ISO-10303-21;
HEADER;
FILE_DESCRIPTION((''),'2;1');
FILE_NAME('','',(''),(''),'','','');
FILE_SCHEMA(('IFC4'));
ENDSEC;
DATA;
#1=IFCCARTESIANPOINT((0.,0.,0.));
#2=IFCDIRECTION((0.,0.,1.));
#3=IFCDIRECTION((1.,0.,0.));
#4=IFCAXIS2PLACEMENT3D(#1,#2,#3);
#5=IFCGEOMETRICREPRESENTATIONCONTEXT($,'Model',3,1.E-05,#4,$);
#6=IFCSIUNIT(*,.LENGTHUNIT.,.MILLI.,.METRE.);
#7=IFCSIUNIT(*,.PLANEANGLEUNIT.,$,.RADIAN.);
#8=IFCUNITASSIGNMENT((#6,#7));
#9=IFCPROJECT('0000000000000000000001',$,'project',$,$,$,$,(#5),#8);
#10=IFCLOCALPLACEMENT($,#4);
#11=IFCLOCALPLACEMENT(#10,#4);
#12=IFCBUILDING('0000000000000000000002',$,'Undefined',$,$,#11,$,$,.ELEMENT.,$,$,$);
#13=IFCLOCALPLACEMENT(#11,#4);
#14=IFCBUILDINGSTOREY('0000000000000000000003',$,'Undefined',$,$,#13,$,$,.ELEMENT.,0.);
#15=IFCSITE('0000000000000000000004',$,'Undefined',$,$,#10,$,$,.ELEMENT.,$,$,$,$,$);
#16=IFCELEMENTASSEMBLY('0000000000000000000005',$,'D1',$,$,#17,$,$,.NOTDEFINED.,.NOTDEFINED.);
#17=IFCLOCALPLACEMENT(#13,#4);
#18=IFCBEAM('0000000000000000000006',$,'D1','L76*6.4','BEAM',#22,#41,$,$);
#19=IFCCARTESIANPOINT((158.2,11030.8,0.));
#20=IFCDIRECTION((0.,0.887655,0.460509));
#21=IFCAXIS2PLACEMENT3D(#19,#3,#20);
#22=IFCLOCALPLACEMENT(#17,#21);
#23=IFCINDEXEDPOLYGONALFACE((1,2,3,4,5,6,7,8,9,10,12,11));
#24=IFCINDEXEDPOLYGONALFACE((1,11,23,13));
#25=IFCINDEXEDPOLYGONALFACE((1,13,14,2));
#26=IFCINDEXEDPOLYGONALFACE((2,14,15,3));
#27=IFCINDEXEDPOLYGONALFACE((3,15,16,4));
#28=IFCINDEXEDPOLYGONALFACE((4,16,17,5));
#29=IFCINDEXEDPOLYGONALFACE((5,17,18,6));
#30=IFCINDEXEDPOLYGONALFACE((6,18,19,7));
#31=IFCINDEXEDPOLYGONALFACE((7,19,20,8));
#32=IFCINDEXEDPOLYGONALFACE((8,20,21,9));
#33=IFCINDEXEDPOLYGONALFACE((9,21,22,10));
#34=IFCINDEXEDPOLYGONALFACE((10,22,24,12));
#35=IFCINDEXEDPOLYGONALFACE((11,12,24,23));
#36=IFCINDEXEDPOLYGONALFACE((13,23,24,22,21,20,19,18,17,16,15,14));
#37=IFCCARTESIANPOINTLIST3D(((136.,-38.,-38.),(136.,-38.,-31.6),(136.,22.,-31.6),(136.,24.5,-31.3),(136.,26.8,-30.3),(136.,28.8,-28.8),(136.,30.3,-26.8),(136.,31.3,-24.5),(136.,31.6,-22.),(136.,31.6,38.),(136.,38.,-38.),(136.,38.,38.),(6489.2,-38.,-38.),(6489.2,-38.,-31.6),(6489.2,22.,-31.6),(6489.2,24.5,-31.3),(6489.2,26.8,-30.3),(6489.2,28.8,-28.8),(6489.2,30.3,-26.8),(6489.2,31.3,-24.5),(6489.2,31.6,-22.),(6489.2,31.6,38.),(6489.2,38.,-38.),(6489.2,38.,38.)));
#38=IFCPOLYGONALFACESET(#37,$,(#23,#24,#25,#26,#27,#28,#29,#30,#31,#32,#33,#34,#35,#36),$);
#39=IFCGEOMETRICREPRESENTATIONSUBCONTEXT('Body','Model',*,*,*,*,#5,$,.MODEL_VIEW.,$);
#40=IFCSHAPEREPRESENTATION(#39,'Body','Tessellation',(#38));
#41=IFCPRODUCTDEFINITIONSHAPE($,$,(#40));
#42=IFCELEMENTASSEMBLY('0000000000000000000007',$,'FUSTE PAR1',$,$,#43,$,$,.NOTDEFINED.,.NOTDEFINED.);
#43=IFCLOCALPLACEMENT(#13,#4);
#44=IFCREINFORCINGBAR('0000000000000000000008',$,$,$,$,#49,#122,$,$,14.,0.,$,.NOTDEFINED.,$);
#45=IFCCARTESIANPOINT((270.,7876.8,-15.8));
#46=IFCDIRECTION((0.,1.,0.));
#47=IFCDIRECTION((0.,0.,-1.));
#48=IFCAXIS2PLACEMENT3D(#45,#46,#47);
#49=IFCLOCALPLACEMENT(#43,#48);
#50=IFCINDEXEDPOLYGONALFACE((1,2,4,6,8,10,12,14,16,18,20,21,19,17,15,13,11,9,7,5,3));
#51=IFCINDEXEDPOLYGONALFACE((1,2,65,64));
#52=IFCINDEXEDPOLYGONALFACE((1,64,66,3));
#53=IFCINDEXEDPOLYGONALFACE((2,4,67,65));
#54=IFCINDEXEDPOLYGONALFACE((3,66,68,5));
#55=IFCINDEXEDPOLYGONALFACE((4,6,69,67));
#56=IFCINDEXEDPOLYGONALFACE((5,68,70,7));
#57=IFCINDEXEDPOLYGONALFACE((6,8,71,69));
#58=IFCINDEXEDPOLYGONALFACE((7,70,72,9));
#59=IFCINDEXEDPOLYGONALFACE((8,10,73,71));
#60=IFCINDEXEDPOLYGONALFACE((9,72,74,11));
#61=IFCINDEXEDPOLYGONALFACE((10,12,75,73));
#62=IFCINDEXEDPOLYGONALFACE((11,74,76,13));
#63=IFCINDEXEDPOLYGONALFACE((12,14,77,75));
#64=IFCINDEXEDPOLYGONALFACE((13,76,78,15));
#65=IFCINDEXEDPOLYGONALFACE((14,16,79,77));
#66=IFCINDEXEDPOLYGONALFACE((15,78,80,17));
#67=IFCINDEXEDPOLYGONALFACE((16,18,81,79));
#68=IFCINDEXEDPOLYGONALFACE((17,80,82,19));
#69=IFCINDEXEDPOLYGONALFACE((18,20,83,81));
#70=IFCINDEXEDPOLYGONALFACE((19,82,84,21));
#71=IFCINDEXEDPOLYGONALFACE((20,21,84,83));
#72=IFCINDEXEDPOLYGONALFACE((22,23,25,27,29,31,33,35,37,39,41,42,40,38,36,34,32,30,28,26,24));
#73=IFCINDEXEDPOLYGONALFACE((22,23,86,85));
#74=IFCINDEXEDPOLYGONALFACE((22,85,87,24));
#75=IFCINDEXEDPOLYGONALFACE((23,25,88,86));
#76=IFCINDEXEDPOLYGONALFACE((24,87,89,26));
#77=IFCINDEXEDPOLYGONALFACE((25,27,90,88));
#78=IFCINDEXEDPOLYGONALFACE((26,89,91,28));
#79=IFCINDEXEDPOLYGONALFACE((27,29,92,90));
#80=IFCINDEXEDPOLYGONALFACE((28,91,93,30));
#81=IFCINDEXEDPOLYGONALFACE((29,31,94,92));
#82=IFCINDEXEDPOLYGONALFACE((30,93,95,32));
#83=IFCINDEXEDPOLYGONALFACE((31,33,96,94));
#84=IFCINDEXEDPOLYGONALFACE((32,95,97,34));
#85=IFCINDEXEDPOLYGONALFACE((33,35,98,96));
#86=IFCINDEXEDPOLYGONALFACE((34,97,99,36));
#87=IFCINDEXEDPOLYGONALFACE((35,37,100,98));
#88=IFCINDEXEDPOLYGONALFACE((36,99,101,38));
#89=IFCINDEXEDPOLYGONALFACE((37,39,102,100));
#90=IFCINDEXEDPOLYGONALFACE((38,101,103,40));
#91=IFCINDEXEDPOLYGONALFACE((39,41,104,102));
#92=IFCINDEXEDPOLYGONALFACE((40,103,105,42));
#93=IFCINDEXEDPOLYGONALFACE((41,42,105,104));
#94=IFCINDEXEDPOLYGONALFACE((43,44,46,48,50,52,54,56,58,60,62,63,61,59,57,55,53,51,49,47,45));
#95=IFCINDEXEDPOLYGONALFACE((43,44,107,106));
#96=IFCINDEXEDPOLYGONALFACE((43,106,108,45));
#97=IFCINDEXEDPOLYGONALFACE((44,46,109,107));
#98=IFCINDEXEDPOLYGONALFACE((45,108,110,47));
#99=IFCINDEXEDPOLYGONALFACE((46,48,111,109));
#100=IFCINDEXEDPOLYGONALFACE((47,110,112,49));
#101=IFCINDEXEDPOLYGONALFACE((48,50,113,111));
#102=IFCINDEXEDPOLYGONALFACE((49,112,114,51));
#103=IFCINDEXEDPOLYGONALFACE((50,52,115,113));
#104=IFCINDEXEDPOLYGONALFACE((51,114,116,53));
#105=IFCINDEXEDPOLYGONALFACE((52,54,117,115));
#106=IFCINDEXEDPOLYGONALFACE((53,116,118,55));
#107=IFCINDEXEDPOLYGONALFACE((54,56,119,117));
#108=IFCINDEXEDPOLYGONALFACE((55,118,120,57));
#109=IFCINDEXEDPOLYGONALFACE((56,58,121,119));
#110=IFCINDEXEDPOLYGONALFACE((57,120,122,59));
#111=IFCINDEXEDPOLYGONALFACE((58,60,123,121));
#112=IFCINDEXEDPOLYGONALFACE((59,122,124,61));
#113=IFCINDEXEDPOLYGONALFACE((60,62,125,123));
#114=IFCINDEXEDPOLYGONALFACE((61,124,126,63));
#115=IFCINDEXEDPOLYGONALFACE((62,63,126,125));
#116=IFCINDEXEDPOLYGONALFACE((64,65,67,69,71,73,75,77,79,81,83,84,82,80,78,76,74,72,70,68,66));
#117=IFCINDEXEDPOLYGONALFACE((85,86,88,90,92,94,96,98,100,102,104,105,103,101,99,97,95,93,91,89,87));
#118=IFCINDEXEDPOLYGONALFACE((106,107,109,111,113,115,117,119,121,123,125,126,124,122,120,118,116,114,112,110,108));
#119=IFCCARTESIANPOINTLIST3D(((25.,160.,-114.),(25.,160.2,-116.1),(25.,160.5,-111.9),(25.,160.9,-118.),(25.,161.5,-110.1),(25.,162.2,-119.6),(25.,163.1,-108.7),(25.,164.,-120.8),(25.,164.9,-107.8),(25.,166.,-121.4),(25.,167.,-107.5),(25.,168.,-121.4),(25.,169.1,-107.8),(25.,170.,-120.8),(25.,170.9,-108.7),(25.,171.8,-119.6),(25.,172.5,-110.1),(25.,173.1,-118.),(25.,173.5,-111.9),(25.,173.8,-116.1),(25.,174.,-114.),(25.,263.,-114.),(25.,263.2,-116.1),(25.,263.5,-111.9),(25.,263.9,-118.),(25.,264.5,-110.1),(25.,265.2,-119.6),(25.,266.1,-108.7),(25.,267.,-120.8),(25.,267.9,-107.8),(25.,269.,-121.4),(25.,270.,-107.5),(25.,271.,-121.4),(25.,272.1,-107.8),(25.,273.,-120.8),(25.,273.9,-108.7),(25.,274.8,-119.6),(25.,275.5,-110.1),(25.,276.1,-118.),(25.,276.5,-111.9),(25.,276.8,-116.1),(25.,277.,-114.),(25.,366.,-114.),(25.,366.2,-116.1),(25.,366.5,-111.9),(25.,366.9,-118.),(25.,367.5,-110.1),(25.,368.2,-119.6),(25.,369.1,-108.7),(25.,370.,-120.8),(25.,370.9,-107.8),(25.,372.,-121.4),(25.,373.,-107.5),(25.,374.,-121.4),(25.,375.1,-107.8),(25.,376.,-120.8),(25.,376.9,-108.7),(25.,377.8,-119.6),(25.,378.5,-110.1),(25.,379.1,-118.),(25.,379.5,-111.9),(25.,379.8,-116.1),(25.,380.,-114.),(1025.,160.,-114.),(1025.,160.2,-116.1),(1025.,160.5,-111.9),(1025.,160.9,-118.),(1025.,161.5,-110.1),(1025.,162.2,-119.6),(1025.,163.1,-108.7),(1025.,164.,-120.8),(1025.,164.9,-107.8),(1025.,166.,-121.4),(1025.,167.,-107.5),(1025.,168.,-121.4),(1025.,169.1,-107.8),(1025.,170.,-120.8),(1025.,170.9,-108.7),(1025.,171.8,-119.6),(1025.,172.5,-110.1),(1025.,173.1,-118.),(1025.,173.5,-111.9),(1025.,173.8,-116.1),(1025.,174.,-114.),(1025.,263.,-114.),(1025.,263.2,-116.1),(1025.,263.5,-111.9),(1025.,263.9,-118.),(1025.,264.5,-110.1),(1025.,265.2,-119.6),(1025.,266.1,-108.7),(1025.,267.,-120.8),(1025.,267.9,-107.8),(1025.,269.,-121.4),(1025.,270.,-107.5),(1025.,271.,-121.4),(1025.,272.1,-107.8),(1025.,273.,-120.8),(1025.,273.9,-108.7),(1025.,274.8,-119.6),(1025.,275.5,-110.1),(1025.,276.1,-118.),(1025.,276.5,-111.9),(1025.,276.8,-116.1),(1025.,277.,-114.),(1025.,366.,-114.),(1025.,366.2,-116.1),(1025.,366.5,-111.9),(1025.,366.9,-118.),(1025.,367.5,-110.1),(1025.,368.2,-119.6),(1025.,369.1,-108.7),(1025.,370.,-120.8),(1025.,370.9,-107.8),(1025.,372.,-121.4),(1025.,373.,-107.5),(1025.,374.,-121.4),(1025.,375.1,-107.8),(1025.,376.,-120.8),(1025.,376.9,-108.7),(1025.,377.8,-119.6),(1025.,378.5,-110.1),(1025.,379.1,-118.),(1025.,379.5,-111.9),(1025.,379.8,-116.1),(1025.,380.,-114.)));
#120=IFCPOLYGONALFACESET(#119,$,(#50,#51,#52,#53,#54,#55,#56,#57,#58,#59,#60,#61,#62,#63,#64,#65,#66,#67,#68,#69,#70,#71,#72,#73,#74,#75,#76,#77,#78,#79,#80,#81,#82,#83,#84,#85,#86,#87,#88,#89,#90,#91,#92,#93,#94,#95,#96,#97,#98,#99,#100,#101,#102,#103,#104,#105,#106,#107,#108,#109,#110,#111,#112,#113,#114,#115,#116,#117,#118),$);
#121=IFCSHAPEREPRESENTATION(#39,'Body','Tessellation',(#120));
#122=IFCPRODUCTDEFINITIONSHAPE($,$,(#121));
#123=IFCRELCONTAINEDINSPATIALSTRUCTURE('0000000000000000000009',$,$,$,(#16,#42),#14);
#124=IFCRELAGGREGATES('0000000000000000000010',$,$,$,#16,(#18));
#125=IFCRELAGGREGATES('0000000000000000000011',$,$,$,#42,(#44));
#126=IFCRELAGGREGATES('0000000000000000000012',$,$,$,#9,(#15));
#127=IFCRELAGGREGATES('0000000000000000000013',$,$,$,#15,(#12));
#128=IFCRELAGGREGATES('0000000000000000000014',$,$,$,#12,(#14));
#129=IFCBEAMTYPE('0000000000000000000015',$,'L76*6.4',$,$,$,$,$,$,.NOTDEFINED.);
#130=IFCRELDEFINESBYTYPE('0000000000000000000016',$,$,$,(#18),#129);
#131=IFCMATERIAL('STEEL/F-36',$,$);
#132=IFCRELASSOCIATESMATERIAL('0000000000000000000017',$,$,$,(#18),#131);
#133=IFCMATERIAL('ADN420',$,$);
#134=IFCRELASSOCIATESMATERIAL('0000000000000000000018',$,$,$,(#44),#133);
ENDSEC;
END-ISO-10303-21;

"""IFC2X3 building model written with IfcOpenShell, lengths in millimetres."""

from ifc_helpers import new_model, entity, si_unit, frame, origin_with_axes, origin_2d_with_axis, place, context, subcontext, project, spatial, l_section, extrude, clip, halfspace, source, transform, mapped, material, type_object, element, aggregate, save


model = new_model("IFC2X3")

# Units and contexts
model_context = context("Model", 3, precision=1e-05, world=origin_with_axes())
body_context = subcontext(model_context, "Body", "Model", "MODEL_VIEW")
ifc_project = project(units=[si_unit("LENGTHUNIT", "METRE", prefix="MILLI"), si_unit("PLANEANGLEUNIT", "RADIAN")], contexts=[model_context])

# Site, building, storey
site_placement = place(None, origin_with_axes())
site = spatial("IfcSite", under=ifc_project, at=site_placement, Name="Undefined", CompositionType="ELEMENT")
building_placement = place(site_placement, origin_with_axes())
building = spatial("IfcBuilding", under=site, at=building_placement, Name="Undefined", CompositionType="ELEMENT")
storey_placement = place(building_placement, origin_with_axes())
storey = spatial("IfcBuildingStorey", under=building, at=storey_placement, Name="Undefined", CompositionType="ELEMENT", Elevation=0.0)

# Element assembly, beam
assembly_1_placement = place(storey_placement, origin_with_axes())
assembly_1 = element("IfcElementAssembly", 1, at=assembly_1_placement, inside=storey, Name="D1", AssemblyPlace="NOTDEFINED", PredefinedType="NOTDEFINED")
ifc_material_1 = material(Name="STEEL/F-36")
beam_type_1 = type_object("IfcBeamType", Name="L76*6.4", PredefinedType="NOTDEFINED")
beam_1_placement = place(assembly_1_placement, frame((158.2, 11030.8, 0.0), z_axis=(1.0, 0.0, 0.0), x_axis=(0.0, 0.887655, 0.460509)))
beam_1 = element("IfcBeam", 2, at=beam_1_placement, type_object=beam_type_1, material=ifc_material_1, Name="D1", Description="L76*6.4", ObjectType="BEAM", context=body_context, shape_type="Clipping", body=[
    clip(extrude(l_section(Depth=76.0, Width=76.0, Thickness=6.4, FilletRadius=9.6, at=origin_2d_with_axis()), frame((6489.2, 0.0, 0.0), z_axis=(-1.0, 0.0, 0.0), x_axis=(0.0, -1.0, 0.0)), (0.0, 0.0, 1.0), 6489.2), halfspace(frame((136.0, 0.0, -44.4), z_axis=(1.0, 0.0, 0.0), x_axis=(0.0, -1.0, 0.0)), True)),
])
aggregate(assembly_1, [beam_1])

# Element assembly, reinforcing bar
assembly_2_placement = place(storey_placement, origin_with_axes())
assembly_2 = element("IfcElementAssembly", 3, at=assembly_2_placement, inside=storey, Name="FUSTE PAR1", AssemblyPlace="NOTDEFINED", PredefinedType="NOTDEFINED")
ifc_material_2 = material(Name="ADN420")
shared_shape_1 = source(origin_with_axes(), body_context, "Body", "AdvancedSweptSolid", [
    entity("IfcSweptDiskSolid", entity("IfcTrimmedCurve", entity("IfcLine", entity("IfcCartesianPoint", [0.0, 0.0, 0.0]), entity("IfcVector", entity("IfcDirection", [1.0, 0.0, 0.0]), 1.0)), [entity("IfcParameterValue", 0.0)], [entity("IfcParameterValue", 1000.0)], True, "PARAMETER"), 7.0, None, 0.0, 1000.0),
])
shared_shape_2 = source(origin_with_axes(), body_context, "Body", "AdvancedSweptSolid", [
    entity("IfcSweptDiskSolid", entity("IfcTrimmedCurve", entity("IfcLine", entity("IfcCartesianPoint", [0.0, 0.0, 0.0]), entity("IfcVector", entity("IfcDirection", [1.0, 0.0, 0.0]), 1.0)), [entity("IfcParameterValue", 0.0)], [entity("IfcParameterValue", 1000.0)], True, "PARAMETER"), 7.0, None, 0.0, 1000.0),
])
shared_shape_3 = source(origin_with_axes(), body_context, "Body", "AdvancedSweptSolid", [
    entity("IfcSweptDiskSolid", entity("IfcTrimmedCurve", entity("IfcLine", entity("IfcCartesianPoint", [0.0, 0.0, 0.0]), entity("IfcVector", entity("IfcDirection", [1.0, 0.0, 0.0]), 1.0)), [entity("IfcParameterValue", 0.0)], [entity("IfcParameterValue", 1000.0)], True, "PARAMETER"), 7.0, None, 0.0, 1000.0),
])
reinforcing_bar_1_placement = place(assembly_2_placement, frame((270.0, 7876.8, -15.8), z_axis=(0.0, 1.0, 0.0), x_axis=(0.0, 0.0, -1.0)))
reinforcing_bar_1 = element("IfcReinforcingBar", 4, at=reinforcing_bar_1_placement, material=ifc_material_2, BarRole="NOTDEFINED", CrossSectionArea=0.0, NominalDiameter=14.0, context=body_context, shape_type="MappedRepresentation", body=[
    mapped(shared_shape_1, transform((25.0, 167.0, -114.5))),
    mapped(shared_shape_2, transform((25.0, 270.0, -114.5))),
    mapped(shared_shape_3, transform((25.0, 373.0, -114.5))),
])
aggregate(assembly_2, [reinforcing_bar_1])

save(model, "model.ifc")
